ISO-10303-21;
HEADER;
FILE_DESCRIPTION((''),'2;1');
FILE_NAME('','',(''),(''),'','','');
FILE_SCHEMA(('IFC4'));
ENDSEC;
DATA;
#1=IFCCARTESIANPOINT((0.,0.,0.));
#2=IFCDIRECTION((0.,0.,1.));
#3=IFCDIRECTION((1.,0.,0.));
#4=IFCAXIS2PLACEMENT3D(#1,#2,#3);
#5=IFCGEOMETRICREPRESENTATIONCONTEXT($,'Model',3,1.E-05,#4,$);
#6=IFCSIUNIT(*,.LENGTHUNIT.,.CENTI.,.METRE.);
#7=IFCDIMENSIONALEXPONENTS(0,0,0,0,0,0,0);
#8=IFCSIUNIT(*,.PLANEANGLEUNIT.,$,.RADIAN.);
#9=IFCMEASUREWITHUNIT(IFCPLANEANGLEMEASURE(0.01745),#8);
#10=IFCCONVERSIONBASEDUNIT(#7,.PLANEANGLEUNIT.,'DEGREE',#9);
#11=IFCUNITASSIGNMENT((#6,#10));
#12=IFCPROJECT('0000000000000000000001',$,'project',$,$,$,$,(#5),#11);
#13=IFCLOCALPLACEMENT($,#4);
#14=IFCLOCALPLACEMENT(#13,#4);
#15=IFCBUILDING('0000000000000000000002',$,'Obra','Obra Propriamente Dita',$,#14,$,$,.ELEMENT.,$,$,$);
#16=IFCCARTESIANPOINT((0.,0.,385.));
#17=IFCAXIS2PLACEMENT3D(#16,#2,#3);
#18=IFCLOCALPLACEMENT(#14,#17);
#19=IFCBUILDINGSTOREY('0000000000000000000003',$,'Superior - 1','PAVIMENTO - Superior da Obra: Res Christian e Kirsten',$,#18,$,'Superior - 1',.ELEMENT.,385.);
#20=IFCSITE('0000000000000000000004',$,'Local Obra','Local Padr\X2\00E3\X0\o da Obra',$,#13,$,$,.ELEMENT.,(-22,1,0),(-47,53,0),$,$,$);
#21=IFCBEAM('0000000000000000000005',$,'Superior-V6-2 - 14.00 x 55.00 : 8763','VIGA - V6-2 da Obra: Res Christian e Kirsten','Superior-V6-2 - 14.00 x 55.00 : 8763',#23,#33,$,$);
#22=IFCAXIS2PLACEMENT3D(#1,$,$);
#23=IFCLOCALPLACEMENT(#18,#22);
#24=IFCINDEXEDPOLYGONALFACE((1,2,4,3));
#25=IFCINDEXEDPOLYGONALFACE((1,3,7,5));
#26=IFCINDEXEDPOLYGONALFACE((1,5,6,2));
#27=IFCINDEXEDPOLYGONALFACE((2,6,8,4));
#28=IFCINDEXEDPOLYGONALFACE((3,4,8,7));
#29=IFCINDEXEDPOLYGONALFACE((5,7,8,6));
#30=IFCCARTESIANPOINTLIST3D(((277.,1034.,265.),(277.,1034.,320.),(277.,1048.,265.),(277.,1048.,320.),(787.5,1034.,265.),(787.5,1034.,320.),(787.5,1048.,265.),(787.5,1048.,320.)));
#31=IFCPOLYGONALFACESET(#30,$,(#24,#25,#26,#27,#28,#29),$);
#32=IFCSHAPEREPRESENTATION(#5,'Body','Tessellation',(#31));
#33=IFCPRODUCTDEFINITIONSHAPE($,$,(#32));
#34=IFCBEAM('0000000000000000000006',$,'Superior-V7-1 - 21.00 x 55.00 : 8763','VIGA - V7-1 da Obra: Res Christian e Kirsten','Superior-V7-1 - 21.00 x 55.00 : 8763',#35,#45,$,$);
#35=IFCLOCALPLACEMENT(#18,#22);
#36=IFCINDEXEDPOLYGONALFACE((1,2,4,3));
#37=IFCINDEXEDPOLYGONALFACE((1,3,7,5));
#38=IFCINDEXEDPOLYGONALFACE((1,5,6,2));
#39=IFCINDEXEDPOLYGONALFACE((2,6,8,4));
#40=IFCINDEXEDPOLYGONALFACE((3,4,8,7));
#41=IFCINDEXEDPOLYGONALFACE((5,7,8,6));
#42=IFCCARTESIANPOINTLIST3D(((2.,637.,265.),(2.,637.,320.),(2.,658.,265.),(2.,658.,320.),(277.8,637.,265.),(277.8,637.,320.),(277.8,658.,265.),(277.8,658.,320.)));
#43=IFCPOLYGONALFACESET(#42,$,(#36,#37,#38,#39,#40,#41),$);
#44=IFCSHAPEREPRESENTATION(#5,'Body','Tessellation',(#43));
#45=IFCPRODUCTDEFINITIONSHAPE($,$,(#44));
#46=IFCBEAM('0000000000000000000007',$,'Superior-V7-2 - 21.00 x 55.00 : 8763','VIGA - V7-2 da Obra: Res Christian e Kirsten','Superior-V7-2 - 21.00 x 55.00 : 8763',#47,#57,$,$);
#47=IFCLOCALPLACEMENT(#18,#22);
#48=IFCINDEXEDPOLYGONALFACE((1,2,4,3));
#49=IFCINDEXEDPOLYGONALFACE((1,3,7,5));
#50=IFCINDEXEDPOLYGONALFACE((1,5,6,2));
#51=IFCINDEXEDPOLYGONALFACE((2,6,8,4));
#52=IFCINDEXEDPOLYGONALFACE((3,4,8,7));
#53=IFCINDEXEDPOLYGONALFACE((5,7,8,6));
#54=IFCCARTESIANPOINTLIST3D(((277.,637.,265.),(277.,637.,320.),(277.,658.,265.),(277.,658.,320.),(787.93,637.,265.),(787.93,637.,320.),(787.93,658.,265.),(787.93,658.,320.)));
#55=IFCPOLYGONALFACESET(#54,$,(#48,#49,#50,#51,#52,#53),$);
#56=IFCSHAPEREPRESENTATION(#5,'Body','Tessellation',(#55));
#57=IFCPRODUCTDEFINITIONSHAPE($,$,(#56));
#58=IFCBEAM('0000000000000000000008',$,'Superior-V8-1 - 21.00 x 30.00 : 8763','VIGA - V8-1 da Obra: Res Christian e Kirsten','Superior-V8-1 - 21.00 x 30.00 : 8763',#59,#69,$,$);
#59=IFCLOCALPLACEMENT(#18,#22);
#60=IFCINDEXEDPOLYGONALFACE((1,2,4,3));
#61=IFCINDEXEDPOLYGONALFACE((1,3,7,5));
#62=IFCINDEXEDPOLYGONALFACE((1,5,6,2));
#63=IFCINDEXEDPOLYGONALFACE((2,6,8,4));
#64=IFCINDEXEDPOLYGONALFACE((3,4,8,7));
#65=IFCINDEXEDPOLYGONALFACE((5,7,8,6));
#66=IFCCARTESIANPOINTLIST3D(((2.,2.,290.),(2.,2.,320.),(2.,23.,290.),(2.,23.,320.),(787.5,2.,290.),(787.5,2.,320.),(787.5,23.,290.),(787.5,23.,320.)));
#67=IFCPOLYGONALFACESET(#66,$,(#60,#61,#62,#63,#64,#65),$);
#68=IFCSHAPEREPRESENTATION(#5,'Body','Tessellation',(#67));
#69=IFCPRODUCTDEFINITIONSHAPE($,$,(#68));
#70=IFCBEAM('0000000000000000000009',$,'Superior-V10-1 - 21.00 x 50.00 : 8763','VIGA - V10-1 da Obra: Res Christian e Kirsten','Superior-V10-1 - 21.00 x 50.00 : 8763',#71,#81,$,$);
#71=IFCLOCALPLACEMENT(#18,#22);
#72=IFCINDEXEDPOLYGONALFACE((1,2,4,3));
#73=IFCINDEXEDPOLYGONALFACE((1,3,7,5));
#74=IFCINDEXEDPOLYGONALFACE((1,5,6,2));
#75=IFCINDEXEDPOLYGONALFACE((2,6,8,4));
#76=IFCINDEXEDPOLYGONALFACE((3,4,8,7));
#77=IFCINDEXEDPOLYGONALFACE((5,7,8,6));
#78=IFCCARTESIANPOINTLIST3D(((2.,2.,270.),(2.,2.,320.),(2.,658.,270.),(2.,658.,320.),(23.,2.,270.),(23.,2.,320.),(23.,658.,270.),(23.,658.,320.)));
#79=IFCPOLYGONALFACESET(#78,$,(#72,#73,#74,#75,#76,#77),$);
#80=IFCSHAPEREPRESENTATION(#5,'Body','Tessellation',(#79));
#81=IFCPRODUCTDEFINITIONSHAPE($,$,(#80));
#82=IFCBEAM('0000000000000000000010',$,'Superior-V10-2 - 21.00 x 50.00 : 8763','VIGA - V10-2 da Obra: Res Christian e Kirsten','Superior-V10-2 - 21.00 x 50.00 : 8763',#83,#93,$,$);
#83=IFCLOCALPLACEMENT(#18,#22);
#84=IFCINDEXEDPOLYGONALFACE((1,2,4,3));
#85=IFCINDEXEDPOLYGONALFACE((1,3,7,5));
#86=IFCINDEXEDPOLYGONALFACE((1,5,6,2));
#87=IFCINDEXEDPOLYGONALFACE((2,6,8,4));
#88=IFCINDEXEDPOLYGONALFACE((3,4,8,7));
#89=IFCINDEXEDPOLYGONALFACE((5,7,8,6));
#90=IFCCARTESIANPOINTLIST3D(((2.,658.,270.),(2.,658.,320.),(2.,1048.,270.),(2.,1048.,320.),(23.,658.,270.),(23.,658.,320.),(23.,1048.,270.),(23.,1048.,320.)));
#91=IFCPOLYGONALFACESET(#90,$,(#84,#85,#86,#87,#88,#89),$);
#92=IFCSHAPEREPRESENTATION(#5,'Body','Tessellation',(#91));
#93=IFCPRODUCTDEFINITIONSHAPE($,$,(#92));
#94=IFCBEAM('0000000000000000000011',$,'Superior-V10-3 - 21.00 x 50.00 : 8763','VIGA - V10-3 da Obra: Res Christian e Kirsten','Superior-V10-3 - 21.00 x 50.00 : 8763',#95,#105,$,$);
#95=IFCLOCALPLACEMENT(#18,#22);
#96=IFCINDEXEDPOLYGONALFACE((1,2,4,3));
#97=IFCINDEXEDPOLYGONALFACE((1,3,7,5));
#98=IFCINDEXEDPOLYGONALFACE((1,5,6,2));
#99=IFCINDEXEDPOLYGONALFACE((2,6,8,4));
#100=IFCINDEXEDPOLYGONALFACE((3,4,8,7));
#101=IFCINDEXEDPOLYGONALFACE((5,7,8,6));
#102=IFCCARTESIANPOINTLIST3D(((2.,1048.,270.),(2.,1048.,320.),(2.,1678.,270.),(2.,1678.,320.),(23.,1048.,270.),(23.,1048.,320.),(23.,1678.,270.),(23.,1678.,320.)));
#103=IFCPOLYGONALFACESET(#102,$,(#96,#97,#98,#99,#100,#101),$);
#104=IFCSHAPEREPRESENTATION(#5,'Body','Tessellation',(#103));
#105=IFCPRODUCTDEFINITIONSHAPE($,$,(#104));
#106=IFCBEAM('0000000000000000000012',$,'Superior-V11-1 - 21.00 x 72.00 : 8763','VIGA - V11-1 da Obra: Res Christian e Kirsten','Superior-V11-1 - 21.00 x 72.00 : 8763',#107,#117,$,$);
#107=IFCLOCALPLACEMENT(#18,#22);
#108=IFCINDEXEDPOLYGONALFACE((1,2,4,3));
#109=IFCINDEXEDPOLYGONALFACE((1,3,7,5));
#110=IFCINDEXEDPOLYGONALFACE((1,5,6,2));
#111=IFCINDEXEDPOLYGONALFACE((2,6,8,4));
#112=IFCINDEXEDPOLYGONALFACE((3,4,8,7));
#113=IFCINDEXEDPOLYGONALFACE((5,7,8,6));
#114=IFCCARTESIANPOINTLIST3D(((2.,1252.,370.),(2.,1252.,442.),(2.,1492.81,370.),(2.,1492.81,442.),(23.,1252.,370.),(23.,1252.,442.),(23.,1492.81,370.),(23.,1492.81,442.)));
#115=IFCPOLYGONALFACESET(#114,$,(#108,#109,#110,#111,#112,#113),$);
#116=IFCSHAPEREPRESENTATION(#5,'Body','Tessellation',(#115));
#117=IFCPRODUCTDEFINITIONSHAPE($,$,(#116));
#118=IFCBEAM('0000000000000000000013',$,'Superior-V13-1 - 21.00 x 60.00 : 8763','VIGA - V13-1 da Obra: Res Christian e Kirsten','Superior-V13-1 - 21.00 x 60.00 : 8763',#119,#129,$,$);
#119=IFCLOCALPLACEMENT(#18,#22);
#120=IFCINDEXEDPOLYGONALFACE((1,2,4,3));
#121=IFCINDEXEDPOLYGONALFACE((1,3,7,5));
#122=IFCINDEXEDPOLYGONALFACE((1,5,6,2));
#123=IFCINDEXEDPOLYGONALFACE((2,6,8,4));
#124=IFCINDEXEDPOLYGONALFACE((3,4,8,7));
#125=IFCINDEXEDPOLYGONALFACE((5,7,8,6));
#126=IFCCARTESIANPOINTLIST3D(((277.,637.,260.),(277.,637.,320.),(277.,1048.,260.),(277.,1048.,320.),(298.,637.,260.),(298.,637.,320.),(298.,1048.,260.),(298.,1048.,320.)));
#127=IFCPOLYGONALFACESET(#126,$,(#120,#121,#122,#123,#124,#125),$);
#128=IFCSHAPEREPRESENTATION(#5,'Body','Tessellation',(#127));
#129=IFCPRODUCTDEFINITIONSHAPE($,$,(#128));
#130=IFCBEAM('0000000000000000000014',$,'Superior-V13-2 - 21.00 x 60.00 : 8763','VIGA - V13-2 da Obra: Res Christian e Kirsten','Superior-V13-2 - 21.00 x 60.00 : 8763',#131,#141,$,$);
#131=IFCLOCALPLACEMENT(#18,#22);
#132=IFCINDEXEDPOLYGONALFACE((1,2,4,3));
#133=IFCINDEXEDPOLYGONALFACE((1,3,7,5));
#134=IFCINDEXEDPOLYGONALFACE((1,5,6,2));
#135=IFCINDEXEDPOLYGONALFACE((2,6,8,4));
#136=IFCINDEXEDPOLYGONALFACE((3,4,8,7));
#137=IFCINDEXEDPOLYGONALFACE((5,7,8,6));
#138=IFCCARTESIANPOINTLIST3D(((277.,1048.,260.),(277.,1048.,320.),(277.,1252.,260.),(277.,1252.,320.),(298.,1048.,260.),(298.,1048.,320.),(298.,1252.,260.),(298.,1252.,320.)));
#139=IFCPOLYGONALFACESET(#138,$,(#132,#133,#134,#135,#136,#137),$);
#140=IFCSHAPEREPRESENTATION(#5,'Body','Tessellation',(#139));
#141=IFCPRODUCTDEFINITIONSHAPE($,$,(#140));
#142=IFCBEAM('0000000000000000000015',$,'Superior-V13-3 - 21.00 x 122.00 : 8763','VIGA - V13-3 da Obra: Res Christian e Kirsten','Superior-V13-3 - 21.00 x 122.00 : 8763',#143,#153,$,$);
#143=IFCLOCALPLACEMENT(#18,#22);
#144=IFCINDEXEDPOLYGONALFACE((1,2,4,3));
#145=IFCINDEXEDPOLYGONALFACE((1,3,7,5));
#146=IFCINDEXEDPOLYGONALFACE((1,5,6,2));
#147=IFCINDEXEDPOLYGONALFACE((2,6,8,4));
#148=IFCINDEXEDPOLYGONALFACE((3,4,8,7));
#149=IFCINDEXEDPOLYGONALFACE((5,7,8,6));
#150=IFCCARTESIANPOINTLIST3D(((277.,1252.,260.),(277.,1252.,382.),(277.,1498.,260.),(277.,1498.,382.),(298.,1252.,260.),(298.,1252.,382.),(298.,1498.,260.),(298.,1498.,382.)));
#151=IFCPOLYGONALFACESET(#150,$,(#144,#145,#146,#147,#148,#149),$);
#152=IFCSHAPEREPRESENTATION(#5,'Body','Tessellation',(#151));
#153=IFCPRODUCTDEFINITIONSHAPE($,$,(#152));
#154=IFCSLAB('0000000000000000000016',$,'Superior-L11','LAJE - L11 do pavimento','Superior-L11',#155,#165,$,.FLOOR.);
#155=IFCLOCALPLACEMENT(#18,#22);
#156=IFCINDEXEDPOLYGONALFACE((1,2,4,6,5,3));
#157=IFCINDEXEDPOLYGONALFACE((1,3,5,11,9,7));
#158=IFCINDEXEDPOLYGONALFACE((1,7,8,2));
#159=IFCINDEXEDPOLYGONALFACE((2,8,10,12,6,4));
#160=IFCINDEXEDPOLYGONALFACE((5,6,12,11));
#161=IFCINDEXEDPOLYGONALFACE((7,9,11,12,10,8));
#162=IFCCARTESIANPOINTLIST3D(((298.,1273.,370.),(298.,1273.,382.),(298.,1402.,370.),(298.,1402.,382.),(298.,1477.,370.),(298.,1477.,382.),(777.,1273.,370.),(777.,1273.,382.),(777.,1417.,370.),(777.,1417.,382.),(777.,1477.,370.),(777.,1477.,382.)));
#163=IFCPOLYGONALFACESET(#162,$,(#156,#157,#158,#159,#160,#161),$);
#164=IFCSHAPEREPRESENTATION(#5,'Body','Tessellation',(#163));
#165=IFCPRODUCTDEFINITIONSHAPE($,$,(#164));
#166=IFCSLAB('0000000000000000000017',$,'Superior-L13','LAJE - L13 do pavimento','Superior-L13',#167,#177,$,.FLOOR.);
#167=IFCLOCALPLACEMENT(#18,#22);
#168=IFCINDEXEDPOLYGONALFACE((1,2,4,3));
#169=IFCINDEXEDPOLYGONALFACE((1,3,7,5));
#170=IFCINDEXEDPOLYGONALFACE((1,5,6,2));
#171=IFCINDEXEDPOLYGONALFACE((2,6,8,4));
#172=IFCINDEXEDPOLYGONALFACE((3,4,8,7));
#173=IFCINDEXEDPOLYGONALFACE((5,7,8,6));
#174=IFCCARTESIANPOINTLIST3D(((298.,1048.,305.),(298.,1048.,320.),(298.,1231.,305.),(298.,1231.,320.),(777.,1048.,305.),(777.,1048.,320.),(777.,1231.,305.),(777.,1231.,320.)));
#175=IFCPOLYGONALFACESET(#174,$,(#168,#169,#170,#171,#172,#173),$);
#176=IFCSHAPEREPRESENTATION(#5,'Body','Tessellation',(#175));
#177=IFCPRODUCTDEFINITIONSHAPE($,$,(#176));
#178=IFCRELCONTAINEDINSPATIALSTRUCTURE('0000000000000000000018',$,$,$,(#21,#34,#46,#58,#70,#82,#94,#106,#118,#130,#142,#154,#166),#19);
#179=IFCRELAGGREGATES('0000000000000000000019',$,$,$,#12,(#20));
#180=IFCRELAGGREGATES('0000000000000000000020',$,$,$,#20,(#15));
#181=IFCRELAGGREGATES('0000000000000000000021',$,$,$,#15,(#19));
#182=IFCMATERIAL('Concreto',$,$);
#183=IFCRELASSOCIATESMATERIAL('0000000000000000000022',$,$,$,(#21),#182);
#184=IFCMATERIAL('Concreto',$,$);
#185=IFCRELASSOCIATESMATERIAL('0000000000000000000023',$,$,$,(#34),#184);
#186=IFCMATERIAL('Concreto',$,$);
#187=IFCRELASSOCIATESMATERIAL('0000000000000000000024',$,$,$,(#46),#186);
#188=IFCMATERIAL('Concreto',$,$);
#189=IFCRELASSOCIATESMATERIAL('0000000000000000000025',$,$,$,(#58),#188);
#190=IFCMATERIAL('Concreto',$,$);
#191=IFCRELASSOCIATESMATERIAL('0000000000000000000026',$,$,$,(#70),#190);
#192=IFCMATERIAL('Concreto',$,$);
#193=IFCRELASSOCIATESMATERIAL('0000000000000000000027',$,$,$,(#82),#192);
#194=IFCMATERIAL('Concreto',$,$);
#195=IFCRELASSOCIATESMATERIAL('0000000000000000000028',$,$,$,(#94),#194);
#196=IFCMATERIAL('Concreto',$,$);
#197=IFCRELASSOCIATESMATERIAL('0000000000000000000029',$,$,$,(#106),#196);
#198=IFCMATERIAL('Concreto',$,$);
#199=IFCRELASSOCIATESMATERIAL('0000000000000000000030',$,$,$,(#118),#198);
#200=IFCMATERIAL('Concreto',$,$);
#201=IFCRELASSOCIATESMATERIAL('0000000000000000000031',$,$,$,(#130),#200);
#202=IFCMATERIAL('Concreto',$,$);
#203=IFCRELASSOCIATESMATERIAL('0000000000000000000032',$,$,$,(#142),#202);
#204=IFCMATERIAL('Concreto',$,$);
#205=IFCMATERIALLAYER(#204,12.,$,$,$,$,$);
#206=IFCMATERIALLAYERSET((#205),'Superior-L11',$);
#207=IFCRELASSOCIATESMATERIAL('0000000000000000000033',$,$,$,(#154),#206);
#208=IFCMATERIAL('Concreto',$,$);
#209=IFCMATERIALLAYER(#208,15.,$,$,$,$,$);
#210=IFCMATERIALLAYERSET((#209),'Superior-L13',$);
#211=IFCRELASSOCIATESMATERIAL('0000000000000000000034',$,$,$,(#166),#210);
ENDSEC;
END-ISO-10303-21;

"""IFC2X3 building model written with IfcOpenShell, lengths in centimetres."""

from ifc_helpers import new_model, entity, si_unit, converted_unit, frame, origin_with_axes, place, context, project, spatial, polyline, outline, extrude, material, layer, layer_set, layer_usage, element, save


model = new_model("IFC2X3")

# Units and contexts
model_context = context("Model", 3, precision=1e-05, world=origin_with_axes())
ifc_project = project(units=[si_unit("LENGTHUNIT", "METRE", prefix="CENTI"), converted_unit("PLANEANGLEUNIT", "DEGREE", entity("IfcPlaneAngleMeasure", 0.01745), si_unit("PLANEANGLEUNIT", "RADIAN"), dimensions=[0, 0, 0, 0, 0, 0, 0])], contexts=[model_context])

# Site, building, storey
site_placement = place(None, origin_with_axes())
site = spatial("IfcSite", under=ifc_project, at=site_placement, Name="Local Obra", Description="Local Padrão da Obra", CompositionType="ELEMENT", RefLatitude=(-22, 1, 0), RefLongitude=(-47, 53, 0))
building_placement = place(site_placement, origin_with_axes())
building = spatial("IfcBuilding", under=site, at=building_placement, Name="Obra", Description="Obra Propriamente Dita", CompositionType="ELEMENT")
storey_placement = place(building_placement, frame((0.0, 0.0, 385.0), z_axis=(0.0, 0.0, 1.0), x_axis=(1.0, 0.0, 0.0)))
storey = spatial("IfcBuildingStorey", under=building, at=storey_placement, Name="Superior - 1", Description="PAVIMENTO - Superior da Obra: Res Christian e Kirsten", LongName="Superior - 1", CompositionType="ELEMENT", Elevation=385.0)

# Beams
ifc_material_1 = material(Name="Concreto")
beam_1_placement = place(storey_placement, frame((277.0, 1048.0, 320.0), z_axis=(1.0, 0.0, 0.0), x_axis=(0.0, -1.0, 0.0)))
element("IfcBeam", 1, at=beam_1_placement, inside=storey, material=ifc_material_1, Name="Superior-V6-2 - 14.00 x 55.00 : 8763", Description="VIGA - V6-2 da Obra: Res Christian e Kirsten", ObjectType="Superior-V6-2 - 14.00 x 55.00 : 8763", context=model_context, shape_type="SweptSolid", body=[
    extrude(outline(polyline([(0.0, 0.0), (14.0, 0.0), (14.0, 55.0), (0.0, 55.0), (0.0, 0.0)])), origin_with_axes(), (0.0, 0.0, 1.0), 510.5),
])
ifc_material_2 = material(Name="Concreto")
beam_2_placement = place(storey_placement, frame((2.0, 658.0, 320.0), z_axis=(1.0, -0.000001, 0.0), x_axis=(-0.000001, -1.0, 0.0)))
element("IfcBeam", 2, at=beam_2_placement, inside=storey, material=ifc_material_2, Name="Superior-V7-1 - 21.00 x 55.00 : 8763", Description="VIGA - V7-1 da Obra: Res Christian e Kirsten", ObjectType="Superior-V7-1 - 21.00 x 55.00 : 8763", context=model_context, shape_type="SweptSolid", body=[
    extrude(outline(polyline([(0.0, 0.0), (21.0, 0.0), (21.0, 55.0), (0.0, 55.0), (0.0, 0.0)])), origin_with_axes(), (0.0, 0.0, 1.0), 275.8),
])
ifc_material_3 = material(Name="Concreto")
beam_3_placement = place(storey_placement, frame((277.0, 637.0, 320.0), z_axis=(1.0, 0.0, 0.0), x_axis=(0.0, -1.0, 0.0)))
element("IfcBeam", 3, at=beam_3_placement, inside=storey, material=ifc_material_3, Name="Superior-V7-2 - 21.00 x 55.00 : 8763", Description="VIGA - V7-2 da Obra: Res Christian e Kirsten", ObjectType="Superior-V7-2 - 21.00 x 55.00 : 8763", context=model_context, shape_type="SweptSolid", body=[
    extrude(outline(polyline([(-21.0, 0.0), (0.0, 0.0), (0.0, 55.0), (-21.0, 55.0), (-21.0, 0.0)])), origin_with_axes(), (0.0, 0.0, 1.0), 510.93),
])
ifc_material_4 = material(Name="Concreto")
beam_4_placement = place(storey_placement, frame((2.0, 2.0, 320.0), z_axis=(1.0, 0.0, 0.0), x_axis=(0.0, -1.0, 0.0)))
element("IfcBeam", 4, at=beam_4_placement, inside=storey, material=ifc_material_4, Name="Superior-V8-1 - 21.00 x 30.00 : 8763", Description="VIGA - V8-1 da Obra: Res Christian e Kirsten", ObjectType="Superior-V8-1 - 21.00 x 30.00 : 8763", context=model_context, shape_type="SweptSolid", body=[
    extrude(outline(polyline([(-21.0, 0.0), (0.0, 0.0), (0.0, 30.0), (-21.0, 30.0), (-21.0, 0.0)])), origin_with_axes(), (0.0, 0.0, 1.0), 785.5),
])
ifc_material_5 = material(Name="Concreto")
beam_5_placement = place(storey_placement, frame((2.0, 2.0, 320.0), z_axis=(0.0, 1.0, 0.0), x_axis=(1.0, 0.0, 0.0)))
element("IfcBeam", 5, at=beam_5_placement, inside=storey, material=ifc_material_5, Name="Superior-V10-1 - 21.00 x 50.00 : 8763", Description="VIGA - V10-1 da Obra: Res Christian e Kirsten", ObjectType="Superior-V10-1 - 21.00 x 50.00 : 8763", context=model_context, shape_type="SweptSolid", body=[
    extrude(outline(polyline([(0.0, 0.0), (21.0, 0.0), (21.0, 50.0), (0.0, 50.0), (0.0, 0.0)])), origin_with_axes(), (0.0, 0.0, 1.0), 656.0),
])
ifc_material_6 = material(Name="Concreto")
beam_6_placement = place(storey_placement, frame((2.0, 658.0, 320.0), z_axis=(0.0, 1.0, 0.0), x_axis=(1.0, 0.0, 0.0)))
element("IfcBeam", 6, at=beam_6_placement, inside=storey, material=ifc_material_6, Name="Superior-V10-2 - 21.00 x 50.00 : 8763", Description="VIGA - V10-2 da Obra: Res Christian e Kirsten", ObjectType="Superior-V10-2 - 21.00 x 50.00 : 8763", context=model_context, shape_type="SweptSolid", body=[
    extrude(outline(polyline([(0.0, 0.0), (21.0, 0.0), (21.0, 50.0), (0.0, 50.0), (0.0, 0.0)])), origin_with_axes(), (0.0, 0.0, 1.0), 390.0),
])
ifc_material_7 = material(Name="Concreto")
beam_7_placement = place(storey_placement, frame((2.0, 1048.0, 320.0), z_axis=(0.0, 1.0, 0.0), x_axis=(1.0, 0.0, 0.0)))
element("IfcBeam", 7, at=beam_7_placement, inside=storey, material=ifc_material_7, Name="Superior-V10-3 - 21.00 x 50.00 : 8763", Description="VIGA - V10-3 da Obra: Res Christian e Kirsten", ObjectType="Superior-V10-3 - 21.00 x 50.00 : 8763", context=model_context, shape_type="SweptSolid", body=[
    extrude(outline(polyline([(0.0, 0.0), (21.0, 0.0), (21.0, 50.0), (0.0, 50.0), (0.0, 0.0)])), origin_with_axes(), (0.0, 0.0, 1.0), 630.0),
])
ifc_material_8 = material(Name="Concreto")
beam_8_placement = place(storey_placement, frame((2.0, 1252.0, 442.0), z_axis=(-0.000002, 1.0, 0.0), x_axis=(1.0, 0.000002, 0.0)))
element("IfcBeam", 8, at=beam_8_placement, inside=storey, material=ifc_material_8, Name="Superior-V11-1 - 21.00 x 72.00 : 8763", Description="VIGA - V11-1 da Obra: Res Christian e Kirsten", ObjectType="Superior-V11-1 - 21.00 x 72.00 : 8763", context=model_context, shape_type="SweptSolid", body=[
    extrude(outline(polyline([(0.0, 0.0), (21.0, 0.0), (21.0, 72.0), (0.0, 72.0), (0.0, 0.0)])), origin_with_axes(), (0.0, 0.0, 1.0), 240.81),
])
ifc_material_9 = material(Name="Concreto")
beam_9_placement = place(storey_placement, frame((277.0, 637.0, 320.0), z_axis=(0.0, 1.0, 0.0), x_axis=(1.0, 0.0, 0.0)))
element("IfcBeam", 9, at=beam_9_placement, inside=storey, material=ifc_material_9, Name="Superior-V13-1 - 21.00 x 60.00 : 8763", Description="VIGA - V13-1 da Obra: Res Christian e Kirsten", ObjectType="Superior-V13-1 - 21.00 x 60.00 : 8763", context=model_context, shape_type="SweptSolid", body=[
    extrude(outline(polyline([(0.0, 0.0), (21.0, 0.0), (21.0, 60.0), (0.0, 60.0), (0.0, 0.0)])), origin_with_axes(), (0.0, 0.0, 1.0), 411.0),
])
ifc_material_10 = material(Name="Concreto")
beam_10_placement = place(storey_placement, frame((277.0, 1048.0, 320.0), z_axis=(0.0, 1.0, 0.0), x_axis=(1.0, 0.0, 0.0)))
element("IfcBeam", 10, at=beam_10_placement, inside=storey, material=ifc_material_10, Name="Superior-V13-2 - 21.00 x 60.00 : 8763", Description="VIGA - V13-2 da Obra: Res Christian e Kirsten", ObjectType="Superior-V13-2 - 21.00 x 60.00 : 8763", context=model_context, shape_type="SweptSolid", body=[
    extrude(outline(polyline([(0.0, 0.0), (21.0, 0.0), (21.0, 60.0), (0.0, 60.0), (0.0, 0.0)])), origin_with_axes(), (0.0, 0.0, 1.0), 204.0),
])
ifc_material_11 = material(Name="Concreto")
beam_11_placement = place(storey_placement, frame((277.0, 1252.0, 382.0), z_axis=(0.0, 1.0, 0.0), x_axis=(1.0, 0.0, 0.0)))
element("IfcBeam", 11, at=beam_11_placement, inside=storey, material=ifc_material_11, Name="Superior-V13-3 - 21.00 x 122.00 : 8763", Description="VIGA - V13-3 da Obra: Res Christian e Kirsten", ObjectType="Superior-V13-3 - 21.00 x 122.00 : 8763", context=model_context, shape_type="SweptSolid", body=[
    extrude(outline(polyline([(0.0, 0.0), (21.0, 0.0), (21.0, 122.0), (0.0, 122.0), (0.0, 0.0)])), origin_with_axes(), (0.0, 0.0, 1.0), 246.0),
])

# Slabs
ifc_material_12 = material(Name="Concreto")
ifc_layer_1 = layer(ifc_material_12, 12.0)
ifc_layer_set_1 = layer_set([ifc_layer_1], Name="Superior-L11")
ifc_layer_usage_1 = layer_usage(ifc_layer_set_1, "AXIS3", "POSITIVE", 0.0)
slab_1_placement = place(storey_placement, frame((777.0, 1417.0, 370.0), z_axis=(0.0, 0.0, 1.0), x_axis=(1.0, 0.0, 0.0)))
element("IfcSlab", 12, at=slab_1_placement, inside=storey, material=ifc_layer_usage_1, Name="Superior-L11", Description="LAJE - L11 do pavimento", ObjectType="Superior-L11", PredefinedType="FLOOR", context=model_context, shape_type="SweptSolid", body=[
    extrude(outline(polyline([(0.0, 60.0), (-479.0, 60.0), (-479.0, -15.0), (-479.0, -144.0), (0.0, -144.0), (0.0, 0.0), (0.0, 60.0)])), origin_with_axes(), (0.0, 0.0, 1.0), 12.0),
])
ifc_material_13 = material(Name="Concreto")
ifc_layer_2 = layer(ifc_material_13, 15.0)
ifc_layer_set_2 = layer_set([ifc_layer_2], Name="Superior-L13")
ifc_layer_usage_2 = layer_usage(ifc_layer_set_2, "AXIS3", "POSITIVE", 0.0)
slab_2_placement = place(storey_placement, frame((777.0, 1048.0, 305.0), z_axis=(0.0, 0.0, 1.0), x_axis=(1.0, 0.0, 0.0)))
element("IfcSlab", 13, at=slab_2_placement, inside=storey, material=ifc_layer_usage_2, Name="Superior-L13", Description="LAJE - L13 do pavimento", ObjectType="Superior-L13", PredefinedType="FLOOR", context=model_context, shape_type="SweptSolid", body=[
    extrude(outline(polyline([(0.0, 183.0), (-479.0, 183.0), (-479.0, 0.0), (0.0, 0.0), (0.0, 183.0)])), origin_with_axes(), (0.0, 0.0, 1.0), 15.0),
])

save(model, "model.ifc")
